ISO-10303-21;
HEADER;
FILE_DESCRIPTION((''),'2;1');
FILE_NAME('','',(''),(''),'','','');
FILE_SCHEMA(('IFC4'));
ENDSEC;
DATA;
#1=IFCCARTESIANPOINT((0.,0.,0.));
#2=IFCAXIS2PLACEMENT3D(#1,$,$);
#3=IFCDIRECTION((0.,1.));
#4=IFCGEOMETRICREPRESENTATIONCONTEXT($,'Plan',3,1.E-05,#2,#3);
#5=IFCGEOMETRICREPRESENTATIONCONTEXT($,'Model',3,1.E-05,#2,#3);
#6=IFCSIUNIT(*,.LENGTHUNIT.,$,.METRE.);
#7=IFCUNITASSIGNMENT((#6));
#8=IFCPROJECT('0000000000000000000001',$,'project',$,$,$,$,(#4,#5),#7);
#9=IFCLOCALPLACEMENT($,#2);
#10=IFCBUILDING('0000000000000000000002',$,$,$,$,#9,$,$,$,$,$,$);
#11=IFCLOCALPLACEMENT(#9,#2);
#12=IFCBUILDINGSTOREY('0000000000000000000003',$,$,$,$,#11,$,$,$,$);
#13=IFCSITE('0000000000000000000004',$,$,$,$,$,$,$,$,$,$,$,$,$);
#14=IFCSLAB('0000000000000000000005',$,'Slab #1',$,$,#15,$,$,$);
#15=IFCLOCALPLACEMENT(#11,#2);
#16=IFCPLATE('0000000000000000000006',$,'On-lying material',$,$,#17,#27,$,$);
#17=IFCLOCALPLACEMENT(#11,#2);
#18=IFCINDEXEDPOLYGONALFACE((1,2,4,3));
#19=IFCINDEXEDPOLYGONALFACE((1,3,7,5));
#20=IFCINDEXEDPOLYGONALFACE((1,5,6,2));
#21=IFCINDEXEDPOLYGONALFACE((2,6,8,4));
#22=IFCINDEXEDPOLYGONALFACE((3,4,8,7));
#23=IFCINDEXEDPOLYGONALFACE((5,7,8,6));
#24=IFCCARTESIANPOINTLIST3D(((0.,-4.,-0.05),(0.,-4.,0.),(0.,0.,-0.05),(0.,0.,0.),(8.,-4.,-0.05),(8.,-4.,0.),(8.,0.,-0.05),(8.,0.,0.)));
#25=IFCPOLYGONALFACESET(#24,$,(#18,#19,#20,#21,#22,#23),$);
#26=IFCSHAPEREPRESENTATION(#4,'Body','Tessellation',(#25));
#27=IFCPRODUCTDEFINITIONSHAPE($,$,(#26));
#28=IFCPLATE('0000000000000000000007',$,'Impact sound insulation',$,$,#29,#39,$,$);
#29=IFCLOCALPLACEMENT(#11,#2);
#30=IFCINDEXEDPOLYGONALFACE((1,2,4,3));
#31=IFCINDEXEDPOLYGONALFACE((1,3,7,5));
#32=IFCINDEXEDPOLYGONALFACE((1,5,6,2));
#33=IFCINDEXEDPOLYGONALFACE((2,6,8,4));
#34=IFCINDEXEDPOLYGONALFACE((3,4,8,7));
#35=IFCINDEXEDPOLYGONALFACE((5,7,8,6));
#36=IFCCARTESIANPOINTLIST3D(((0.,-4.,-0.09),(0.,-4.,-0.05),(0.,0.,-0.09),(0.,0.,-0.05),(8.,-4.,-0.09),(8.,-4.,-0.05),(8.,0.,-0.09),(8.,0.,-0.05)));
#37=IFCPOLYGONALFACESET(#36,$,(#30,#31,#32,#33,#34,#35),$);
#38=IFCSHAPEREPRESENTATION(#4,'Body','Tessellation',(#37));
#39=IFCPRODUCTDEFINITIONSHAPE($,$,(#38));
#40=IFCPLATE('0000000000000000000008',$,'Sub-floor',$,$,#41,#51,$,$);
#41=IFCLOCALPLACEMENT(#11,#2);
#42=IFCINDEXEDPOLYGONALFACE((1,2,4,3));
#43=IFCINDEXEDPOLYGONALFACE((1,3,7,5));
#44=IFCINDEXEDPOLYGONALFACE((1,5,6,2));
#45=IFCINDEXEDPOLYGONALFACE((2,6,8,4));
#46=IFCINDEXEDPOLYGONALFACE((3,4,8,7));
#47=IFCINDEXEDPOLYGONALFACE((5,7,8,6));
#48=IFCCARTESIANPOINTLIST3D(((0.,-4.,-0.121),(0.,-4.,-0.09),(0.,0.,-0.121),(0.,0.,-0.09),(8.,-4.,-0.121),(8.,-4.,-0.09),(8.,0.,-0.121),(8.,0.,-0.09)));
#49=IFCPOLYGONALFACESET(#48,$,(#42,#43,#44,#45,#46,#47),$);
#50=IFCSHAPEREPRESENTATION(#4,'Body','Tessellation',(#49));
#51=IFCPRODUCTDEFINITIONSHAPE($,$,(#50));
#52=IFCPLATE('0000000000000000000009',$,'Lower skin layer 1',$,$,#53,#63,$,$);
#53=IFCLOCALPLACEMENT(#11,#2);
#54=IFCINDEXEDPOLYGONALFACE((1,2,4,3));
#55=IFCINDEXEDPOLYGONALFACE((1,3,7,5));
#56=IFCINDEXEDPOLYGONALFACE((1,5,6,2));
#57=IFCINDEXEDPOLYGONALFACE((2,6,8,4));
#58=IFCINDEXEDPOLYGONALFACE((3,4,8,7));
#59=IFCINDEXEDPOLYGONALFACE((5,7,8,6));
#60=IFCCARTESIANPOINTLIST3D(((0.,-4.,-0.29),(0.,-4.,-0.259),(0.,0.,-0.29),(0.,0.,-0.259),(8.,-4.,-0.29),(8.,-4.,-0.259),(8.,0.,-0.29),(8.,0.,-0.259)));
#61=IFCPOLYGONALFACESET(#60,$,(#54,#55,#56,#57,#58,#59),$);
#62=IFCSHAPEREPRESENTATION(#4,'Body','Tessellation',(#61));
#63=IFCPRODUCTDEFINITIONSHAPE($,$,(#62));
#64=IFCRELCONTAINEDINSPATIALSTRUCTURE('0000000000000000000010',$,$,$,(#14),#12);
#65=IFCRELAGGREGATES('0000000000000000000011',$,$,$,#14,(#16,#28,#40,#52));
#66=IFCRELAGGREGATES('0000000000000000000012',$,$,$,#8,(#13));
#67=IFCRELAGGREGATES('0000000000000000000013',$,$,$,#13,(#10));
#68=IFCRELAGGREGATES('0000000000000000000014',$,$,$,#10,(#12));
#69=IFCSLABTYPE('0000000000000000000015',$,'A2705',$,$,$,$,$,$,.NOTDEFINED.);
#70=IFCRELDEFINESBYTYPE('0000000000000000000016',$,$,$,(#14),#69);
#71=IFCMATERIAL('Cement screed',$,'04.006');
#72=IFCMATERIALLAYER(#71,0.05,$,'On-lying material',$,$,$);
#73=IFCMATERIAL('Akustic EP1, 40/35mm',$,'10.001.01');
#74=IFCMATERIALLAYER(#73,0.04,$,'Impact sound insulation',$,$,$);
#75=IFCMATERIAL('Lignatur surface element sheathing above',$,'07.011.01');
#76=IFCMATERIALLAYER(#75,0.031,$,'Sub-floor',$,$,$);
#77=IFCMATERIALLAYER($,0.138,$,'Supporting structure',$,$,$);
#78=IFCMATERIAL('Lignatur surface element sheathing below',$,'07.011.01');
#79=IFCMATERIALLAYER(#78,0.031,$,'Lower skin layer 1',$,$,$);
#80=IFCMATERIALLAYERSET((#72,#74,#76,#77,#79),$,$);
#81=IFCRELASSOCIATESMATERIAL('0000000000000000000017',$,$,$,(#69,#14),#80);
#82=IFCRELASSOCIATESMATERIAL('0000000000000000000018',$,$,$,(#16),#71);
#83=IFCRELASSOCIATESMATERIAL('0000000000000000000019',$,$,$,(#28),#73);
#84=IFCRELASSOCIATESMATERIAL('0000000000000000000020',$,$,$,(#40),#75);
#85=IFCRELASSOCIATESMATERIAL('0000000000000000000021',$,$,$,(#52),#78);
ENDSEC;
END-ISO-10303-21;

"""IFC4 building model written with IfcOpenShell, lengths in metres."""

from ifc_helpers import new_model, si_unit, direction, frame, frame_2d, origin, origin_with_axes, place, context, project, spatial, rectangle, extrude, material, layer, layer_set, type_object, element, aggregate, save


model = new_model("IFC4")

# Units and contexts
plan_context = context("Plan", 3, precision=1e-05, world=origin(), true_north=direction((0.0, 1.0)))
model_context = context("Model", 3, precision=1e-05, world=origin(), true_north=direction((0.0, 1.0)))
ifc_project = project(units=[si_unit("LENGTHUNIT", "METRE")], contexts=[plan_context, model_context])

# Site, building, storey
site = spatial("IfcSite", under=ifc_project)
building_placement = place(None, origin())
building = spatial("IfcBuilding", under=site, at=building_placement)
storey_placement = place(building_placement, origin())
storey = spatial("IfcBuildingStorey", under=building, at=storey_placement)

# Slab, plates
ifc_material_1 = material(Name="Cement screed", Category="04.006")
ifc_layer_1 = layer(ifc_material_1, 0.05, Name="On-lying material")
ifc_material_2 = material(Name="Akustic EP1, 40/35mm", Category="10.001.01")
ifc_layer_2 = layer(ifc_material_2, 0.04, Name="Impact sound insulation")
ifc_material_3 = material(Name="Lignatur surface element sheathing above", Category="07.011.01")
ifc_layer_3 = layer(ifc_material_3, 0.031, Name="Sub-floor")
ifc_layer_4 = layer(None, 0.138, Name="Supporting structure")
ifc_material_4 = material(Name="Lignatur surface element sheathing below", Category="07.011.01")
ifc_layer_5 = layer(ifc_material_4, 0.031, Name="Lower skin layer 1")
ifc_layer_set = layer_set([ifc_layer_1, ifc_layer_2, ifc_layer_3, ifc_layer_4, ifc_layer_5])
slab_type = type_object("IfcSlabType", Name="A2705", PredefinedType="NOTDEFINED", material=ifc_layer_set)
slab_placement = place(None, frame((0.0, 0.0, 0.0), z_axis=(0.0, 0.0, -1.0), x_axis=(1.0, 0.0, 0.0)))
slab = element("IfcSlab", 1, at=slab_placement, inside=storey, type_object=slab_type, material=ifc_layer_set, Name="Slab #1")
plate_1_placement = place(slab_placement, origin())
plate_1 = element("IfcPlate", 2, at=plate_1_placement, material=ifc_material_1, Name="On-lying material", context=plan_context, shape_type="SweptSolid", body=[
    extrude(rectangle(XDim=8.0, YDim=4.0, at=frame_2d((4.0, 2.0), x_axis=(1.0, 0.0))), origin_with_axes(), (0.0, 0.0, 1.0), 0.05),
])
plate_2_placement = place(slab_placement, origin())
plate_2 = element("IfcPlate", 3, at=plate_2_placement, material=ifc_material_2, Name="Impact sound insulation", context=plan_context, shape_type="SweptSolid", body=[
    extrude(rectangle(XDim=8.0, YDim=4.0, at=frame_2d((4.0, 2.0), x_axis=(1.0, 0.0))), frame((0.0, 0.0, 0.05), z_axis=(0.0, 0.0, 1.0), x_axis=(1.0, 0.0, 0.0)), (0.0, 0.0, 1.0), 0.04),
])
plate_3_placement = place(slab_placement, origin())
plate_3 = element("IfcPlate", 4, at=plate_3_placement, material=ifc_material_3, Name="Sub-floor", context=plan_context, shape_type="SweptSolid", body=[
    extrude(rectangle(XDim=8.0, YDim=4.0, at=frame_2d((4.0, 2.0), x_axis=(1.0, 0.0))), frame((0.0, 0.0, 0.09), z_axis=(0.0, 0.0, 1.0), x_axis=(1.0, 0.0, 0.0)), (0.0, 0.0, 1.0), 0.031),
])
plate_4_placement = place(slab_placement, origin())
plate_4 = element("IfcPlate", 5, at=plate_4_placement, material=ifc_material_4, Name="Lower skin layer 1", context=plan_context, shape_type="SweptSolid", body=[
    extrude(rectangle(XDim=8.0, YDim=4.0, at=frame_2d((4.0, 2.0), x_axis=(1.0, 0.0))), frame((0.0, 0.0, 0.259), z_axis=(0.0, 0.0, 1.0), x_axis=(1.0, 0.0, 0.0)), (0.0, 0.0, 1.0), 0.031),
])
aggregate(slab, [plate_1, plate_2, plate_3, plate_4])

save(model, "model.ifc")
